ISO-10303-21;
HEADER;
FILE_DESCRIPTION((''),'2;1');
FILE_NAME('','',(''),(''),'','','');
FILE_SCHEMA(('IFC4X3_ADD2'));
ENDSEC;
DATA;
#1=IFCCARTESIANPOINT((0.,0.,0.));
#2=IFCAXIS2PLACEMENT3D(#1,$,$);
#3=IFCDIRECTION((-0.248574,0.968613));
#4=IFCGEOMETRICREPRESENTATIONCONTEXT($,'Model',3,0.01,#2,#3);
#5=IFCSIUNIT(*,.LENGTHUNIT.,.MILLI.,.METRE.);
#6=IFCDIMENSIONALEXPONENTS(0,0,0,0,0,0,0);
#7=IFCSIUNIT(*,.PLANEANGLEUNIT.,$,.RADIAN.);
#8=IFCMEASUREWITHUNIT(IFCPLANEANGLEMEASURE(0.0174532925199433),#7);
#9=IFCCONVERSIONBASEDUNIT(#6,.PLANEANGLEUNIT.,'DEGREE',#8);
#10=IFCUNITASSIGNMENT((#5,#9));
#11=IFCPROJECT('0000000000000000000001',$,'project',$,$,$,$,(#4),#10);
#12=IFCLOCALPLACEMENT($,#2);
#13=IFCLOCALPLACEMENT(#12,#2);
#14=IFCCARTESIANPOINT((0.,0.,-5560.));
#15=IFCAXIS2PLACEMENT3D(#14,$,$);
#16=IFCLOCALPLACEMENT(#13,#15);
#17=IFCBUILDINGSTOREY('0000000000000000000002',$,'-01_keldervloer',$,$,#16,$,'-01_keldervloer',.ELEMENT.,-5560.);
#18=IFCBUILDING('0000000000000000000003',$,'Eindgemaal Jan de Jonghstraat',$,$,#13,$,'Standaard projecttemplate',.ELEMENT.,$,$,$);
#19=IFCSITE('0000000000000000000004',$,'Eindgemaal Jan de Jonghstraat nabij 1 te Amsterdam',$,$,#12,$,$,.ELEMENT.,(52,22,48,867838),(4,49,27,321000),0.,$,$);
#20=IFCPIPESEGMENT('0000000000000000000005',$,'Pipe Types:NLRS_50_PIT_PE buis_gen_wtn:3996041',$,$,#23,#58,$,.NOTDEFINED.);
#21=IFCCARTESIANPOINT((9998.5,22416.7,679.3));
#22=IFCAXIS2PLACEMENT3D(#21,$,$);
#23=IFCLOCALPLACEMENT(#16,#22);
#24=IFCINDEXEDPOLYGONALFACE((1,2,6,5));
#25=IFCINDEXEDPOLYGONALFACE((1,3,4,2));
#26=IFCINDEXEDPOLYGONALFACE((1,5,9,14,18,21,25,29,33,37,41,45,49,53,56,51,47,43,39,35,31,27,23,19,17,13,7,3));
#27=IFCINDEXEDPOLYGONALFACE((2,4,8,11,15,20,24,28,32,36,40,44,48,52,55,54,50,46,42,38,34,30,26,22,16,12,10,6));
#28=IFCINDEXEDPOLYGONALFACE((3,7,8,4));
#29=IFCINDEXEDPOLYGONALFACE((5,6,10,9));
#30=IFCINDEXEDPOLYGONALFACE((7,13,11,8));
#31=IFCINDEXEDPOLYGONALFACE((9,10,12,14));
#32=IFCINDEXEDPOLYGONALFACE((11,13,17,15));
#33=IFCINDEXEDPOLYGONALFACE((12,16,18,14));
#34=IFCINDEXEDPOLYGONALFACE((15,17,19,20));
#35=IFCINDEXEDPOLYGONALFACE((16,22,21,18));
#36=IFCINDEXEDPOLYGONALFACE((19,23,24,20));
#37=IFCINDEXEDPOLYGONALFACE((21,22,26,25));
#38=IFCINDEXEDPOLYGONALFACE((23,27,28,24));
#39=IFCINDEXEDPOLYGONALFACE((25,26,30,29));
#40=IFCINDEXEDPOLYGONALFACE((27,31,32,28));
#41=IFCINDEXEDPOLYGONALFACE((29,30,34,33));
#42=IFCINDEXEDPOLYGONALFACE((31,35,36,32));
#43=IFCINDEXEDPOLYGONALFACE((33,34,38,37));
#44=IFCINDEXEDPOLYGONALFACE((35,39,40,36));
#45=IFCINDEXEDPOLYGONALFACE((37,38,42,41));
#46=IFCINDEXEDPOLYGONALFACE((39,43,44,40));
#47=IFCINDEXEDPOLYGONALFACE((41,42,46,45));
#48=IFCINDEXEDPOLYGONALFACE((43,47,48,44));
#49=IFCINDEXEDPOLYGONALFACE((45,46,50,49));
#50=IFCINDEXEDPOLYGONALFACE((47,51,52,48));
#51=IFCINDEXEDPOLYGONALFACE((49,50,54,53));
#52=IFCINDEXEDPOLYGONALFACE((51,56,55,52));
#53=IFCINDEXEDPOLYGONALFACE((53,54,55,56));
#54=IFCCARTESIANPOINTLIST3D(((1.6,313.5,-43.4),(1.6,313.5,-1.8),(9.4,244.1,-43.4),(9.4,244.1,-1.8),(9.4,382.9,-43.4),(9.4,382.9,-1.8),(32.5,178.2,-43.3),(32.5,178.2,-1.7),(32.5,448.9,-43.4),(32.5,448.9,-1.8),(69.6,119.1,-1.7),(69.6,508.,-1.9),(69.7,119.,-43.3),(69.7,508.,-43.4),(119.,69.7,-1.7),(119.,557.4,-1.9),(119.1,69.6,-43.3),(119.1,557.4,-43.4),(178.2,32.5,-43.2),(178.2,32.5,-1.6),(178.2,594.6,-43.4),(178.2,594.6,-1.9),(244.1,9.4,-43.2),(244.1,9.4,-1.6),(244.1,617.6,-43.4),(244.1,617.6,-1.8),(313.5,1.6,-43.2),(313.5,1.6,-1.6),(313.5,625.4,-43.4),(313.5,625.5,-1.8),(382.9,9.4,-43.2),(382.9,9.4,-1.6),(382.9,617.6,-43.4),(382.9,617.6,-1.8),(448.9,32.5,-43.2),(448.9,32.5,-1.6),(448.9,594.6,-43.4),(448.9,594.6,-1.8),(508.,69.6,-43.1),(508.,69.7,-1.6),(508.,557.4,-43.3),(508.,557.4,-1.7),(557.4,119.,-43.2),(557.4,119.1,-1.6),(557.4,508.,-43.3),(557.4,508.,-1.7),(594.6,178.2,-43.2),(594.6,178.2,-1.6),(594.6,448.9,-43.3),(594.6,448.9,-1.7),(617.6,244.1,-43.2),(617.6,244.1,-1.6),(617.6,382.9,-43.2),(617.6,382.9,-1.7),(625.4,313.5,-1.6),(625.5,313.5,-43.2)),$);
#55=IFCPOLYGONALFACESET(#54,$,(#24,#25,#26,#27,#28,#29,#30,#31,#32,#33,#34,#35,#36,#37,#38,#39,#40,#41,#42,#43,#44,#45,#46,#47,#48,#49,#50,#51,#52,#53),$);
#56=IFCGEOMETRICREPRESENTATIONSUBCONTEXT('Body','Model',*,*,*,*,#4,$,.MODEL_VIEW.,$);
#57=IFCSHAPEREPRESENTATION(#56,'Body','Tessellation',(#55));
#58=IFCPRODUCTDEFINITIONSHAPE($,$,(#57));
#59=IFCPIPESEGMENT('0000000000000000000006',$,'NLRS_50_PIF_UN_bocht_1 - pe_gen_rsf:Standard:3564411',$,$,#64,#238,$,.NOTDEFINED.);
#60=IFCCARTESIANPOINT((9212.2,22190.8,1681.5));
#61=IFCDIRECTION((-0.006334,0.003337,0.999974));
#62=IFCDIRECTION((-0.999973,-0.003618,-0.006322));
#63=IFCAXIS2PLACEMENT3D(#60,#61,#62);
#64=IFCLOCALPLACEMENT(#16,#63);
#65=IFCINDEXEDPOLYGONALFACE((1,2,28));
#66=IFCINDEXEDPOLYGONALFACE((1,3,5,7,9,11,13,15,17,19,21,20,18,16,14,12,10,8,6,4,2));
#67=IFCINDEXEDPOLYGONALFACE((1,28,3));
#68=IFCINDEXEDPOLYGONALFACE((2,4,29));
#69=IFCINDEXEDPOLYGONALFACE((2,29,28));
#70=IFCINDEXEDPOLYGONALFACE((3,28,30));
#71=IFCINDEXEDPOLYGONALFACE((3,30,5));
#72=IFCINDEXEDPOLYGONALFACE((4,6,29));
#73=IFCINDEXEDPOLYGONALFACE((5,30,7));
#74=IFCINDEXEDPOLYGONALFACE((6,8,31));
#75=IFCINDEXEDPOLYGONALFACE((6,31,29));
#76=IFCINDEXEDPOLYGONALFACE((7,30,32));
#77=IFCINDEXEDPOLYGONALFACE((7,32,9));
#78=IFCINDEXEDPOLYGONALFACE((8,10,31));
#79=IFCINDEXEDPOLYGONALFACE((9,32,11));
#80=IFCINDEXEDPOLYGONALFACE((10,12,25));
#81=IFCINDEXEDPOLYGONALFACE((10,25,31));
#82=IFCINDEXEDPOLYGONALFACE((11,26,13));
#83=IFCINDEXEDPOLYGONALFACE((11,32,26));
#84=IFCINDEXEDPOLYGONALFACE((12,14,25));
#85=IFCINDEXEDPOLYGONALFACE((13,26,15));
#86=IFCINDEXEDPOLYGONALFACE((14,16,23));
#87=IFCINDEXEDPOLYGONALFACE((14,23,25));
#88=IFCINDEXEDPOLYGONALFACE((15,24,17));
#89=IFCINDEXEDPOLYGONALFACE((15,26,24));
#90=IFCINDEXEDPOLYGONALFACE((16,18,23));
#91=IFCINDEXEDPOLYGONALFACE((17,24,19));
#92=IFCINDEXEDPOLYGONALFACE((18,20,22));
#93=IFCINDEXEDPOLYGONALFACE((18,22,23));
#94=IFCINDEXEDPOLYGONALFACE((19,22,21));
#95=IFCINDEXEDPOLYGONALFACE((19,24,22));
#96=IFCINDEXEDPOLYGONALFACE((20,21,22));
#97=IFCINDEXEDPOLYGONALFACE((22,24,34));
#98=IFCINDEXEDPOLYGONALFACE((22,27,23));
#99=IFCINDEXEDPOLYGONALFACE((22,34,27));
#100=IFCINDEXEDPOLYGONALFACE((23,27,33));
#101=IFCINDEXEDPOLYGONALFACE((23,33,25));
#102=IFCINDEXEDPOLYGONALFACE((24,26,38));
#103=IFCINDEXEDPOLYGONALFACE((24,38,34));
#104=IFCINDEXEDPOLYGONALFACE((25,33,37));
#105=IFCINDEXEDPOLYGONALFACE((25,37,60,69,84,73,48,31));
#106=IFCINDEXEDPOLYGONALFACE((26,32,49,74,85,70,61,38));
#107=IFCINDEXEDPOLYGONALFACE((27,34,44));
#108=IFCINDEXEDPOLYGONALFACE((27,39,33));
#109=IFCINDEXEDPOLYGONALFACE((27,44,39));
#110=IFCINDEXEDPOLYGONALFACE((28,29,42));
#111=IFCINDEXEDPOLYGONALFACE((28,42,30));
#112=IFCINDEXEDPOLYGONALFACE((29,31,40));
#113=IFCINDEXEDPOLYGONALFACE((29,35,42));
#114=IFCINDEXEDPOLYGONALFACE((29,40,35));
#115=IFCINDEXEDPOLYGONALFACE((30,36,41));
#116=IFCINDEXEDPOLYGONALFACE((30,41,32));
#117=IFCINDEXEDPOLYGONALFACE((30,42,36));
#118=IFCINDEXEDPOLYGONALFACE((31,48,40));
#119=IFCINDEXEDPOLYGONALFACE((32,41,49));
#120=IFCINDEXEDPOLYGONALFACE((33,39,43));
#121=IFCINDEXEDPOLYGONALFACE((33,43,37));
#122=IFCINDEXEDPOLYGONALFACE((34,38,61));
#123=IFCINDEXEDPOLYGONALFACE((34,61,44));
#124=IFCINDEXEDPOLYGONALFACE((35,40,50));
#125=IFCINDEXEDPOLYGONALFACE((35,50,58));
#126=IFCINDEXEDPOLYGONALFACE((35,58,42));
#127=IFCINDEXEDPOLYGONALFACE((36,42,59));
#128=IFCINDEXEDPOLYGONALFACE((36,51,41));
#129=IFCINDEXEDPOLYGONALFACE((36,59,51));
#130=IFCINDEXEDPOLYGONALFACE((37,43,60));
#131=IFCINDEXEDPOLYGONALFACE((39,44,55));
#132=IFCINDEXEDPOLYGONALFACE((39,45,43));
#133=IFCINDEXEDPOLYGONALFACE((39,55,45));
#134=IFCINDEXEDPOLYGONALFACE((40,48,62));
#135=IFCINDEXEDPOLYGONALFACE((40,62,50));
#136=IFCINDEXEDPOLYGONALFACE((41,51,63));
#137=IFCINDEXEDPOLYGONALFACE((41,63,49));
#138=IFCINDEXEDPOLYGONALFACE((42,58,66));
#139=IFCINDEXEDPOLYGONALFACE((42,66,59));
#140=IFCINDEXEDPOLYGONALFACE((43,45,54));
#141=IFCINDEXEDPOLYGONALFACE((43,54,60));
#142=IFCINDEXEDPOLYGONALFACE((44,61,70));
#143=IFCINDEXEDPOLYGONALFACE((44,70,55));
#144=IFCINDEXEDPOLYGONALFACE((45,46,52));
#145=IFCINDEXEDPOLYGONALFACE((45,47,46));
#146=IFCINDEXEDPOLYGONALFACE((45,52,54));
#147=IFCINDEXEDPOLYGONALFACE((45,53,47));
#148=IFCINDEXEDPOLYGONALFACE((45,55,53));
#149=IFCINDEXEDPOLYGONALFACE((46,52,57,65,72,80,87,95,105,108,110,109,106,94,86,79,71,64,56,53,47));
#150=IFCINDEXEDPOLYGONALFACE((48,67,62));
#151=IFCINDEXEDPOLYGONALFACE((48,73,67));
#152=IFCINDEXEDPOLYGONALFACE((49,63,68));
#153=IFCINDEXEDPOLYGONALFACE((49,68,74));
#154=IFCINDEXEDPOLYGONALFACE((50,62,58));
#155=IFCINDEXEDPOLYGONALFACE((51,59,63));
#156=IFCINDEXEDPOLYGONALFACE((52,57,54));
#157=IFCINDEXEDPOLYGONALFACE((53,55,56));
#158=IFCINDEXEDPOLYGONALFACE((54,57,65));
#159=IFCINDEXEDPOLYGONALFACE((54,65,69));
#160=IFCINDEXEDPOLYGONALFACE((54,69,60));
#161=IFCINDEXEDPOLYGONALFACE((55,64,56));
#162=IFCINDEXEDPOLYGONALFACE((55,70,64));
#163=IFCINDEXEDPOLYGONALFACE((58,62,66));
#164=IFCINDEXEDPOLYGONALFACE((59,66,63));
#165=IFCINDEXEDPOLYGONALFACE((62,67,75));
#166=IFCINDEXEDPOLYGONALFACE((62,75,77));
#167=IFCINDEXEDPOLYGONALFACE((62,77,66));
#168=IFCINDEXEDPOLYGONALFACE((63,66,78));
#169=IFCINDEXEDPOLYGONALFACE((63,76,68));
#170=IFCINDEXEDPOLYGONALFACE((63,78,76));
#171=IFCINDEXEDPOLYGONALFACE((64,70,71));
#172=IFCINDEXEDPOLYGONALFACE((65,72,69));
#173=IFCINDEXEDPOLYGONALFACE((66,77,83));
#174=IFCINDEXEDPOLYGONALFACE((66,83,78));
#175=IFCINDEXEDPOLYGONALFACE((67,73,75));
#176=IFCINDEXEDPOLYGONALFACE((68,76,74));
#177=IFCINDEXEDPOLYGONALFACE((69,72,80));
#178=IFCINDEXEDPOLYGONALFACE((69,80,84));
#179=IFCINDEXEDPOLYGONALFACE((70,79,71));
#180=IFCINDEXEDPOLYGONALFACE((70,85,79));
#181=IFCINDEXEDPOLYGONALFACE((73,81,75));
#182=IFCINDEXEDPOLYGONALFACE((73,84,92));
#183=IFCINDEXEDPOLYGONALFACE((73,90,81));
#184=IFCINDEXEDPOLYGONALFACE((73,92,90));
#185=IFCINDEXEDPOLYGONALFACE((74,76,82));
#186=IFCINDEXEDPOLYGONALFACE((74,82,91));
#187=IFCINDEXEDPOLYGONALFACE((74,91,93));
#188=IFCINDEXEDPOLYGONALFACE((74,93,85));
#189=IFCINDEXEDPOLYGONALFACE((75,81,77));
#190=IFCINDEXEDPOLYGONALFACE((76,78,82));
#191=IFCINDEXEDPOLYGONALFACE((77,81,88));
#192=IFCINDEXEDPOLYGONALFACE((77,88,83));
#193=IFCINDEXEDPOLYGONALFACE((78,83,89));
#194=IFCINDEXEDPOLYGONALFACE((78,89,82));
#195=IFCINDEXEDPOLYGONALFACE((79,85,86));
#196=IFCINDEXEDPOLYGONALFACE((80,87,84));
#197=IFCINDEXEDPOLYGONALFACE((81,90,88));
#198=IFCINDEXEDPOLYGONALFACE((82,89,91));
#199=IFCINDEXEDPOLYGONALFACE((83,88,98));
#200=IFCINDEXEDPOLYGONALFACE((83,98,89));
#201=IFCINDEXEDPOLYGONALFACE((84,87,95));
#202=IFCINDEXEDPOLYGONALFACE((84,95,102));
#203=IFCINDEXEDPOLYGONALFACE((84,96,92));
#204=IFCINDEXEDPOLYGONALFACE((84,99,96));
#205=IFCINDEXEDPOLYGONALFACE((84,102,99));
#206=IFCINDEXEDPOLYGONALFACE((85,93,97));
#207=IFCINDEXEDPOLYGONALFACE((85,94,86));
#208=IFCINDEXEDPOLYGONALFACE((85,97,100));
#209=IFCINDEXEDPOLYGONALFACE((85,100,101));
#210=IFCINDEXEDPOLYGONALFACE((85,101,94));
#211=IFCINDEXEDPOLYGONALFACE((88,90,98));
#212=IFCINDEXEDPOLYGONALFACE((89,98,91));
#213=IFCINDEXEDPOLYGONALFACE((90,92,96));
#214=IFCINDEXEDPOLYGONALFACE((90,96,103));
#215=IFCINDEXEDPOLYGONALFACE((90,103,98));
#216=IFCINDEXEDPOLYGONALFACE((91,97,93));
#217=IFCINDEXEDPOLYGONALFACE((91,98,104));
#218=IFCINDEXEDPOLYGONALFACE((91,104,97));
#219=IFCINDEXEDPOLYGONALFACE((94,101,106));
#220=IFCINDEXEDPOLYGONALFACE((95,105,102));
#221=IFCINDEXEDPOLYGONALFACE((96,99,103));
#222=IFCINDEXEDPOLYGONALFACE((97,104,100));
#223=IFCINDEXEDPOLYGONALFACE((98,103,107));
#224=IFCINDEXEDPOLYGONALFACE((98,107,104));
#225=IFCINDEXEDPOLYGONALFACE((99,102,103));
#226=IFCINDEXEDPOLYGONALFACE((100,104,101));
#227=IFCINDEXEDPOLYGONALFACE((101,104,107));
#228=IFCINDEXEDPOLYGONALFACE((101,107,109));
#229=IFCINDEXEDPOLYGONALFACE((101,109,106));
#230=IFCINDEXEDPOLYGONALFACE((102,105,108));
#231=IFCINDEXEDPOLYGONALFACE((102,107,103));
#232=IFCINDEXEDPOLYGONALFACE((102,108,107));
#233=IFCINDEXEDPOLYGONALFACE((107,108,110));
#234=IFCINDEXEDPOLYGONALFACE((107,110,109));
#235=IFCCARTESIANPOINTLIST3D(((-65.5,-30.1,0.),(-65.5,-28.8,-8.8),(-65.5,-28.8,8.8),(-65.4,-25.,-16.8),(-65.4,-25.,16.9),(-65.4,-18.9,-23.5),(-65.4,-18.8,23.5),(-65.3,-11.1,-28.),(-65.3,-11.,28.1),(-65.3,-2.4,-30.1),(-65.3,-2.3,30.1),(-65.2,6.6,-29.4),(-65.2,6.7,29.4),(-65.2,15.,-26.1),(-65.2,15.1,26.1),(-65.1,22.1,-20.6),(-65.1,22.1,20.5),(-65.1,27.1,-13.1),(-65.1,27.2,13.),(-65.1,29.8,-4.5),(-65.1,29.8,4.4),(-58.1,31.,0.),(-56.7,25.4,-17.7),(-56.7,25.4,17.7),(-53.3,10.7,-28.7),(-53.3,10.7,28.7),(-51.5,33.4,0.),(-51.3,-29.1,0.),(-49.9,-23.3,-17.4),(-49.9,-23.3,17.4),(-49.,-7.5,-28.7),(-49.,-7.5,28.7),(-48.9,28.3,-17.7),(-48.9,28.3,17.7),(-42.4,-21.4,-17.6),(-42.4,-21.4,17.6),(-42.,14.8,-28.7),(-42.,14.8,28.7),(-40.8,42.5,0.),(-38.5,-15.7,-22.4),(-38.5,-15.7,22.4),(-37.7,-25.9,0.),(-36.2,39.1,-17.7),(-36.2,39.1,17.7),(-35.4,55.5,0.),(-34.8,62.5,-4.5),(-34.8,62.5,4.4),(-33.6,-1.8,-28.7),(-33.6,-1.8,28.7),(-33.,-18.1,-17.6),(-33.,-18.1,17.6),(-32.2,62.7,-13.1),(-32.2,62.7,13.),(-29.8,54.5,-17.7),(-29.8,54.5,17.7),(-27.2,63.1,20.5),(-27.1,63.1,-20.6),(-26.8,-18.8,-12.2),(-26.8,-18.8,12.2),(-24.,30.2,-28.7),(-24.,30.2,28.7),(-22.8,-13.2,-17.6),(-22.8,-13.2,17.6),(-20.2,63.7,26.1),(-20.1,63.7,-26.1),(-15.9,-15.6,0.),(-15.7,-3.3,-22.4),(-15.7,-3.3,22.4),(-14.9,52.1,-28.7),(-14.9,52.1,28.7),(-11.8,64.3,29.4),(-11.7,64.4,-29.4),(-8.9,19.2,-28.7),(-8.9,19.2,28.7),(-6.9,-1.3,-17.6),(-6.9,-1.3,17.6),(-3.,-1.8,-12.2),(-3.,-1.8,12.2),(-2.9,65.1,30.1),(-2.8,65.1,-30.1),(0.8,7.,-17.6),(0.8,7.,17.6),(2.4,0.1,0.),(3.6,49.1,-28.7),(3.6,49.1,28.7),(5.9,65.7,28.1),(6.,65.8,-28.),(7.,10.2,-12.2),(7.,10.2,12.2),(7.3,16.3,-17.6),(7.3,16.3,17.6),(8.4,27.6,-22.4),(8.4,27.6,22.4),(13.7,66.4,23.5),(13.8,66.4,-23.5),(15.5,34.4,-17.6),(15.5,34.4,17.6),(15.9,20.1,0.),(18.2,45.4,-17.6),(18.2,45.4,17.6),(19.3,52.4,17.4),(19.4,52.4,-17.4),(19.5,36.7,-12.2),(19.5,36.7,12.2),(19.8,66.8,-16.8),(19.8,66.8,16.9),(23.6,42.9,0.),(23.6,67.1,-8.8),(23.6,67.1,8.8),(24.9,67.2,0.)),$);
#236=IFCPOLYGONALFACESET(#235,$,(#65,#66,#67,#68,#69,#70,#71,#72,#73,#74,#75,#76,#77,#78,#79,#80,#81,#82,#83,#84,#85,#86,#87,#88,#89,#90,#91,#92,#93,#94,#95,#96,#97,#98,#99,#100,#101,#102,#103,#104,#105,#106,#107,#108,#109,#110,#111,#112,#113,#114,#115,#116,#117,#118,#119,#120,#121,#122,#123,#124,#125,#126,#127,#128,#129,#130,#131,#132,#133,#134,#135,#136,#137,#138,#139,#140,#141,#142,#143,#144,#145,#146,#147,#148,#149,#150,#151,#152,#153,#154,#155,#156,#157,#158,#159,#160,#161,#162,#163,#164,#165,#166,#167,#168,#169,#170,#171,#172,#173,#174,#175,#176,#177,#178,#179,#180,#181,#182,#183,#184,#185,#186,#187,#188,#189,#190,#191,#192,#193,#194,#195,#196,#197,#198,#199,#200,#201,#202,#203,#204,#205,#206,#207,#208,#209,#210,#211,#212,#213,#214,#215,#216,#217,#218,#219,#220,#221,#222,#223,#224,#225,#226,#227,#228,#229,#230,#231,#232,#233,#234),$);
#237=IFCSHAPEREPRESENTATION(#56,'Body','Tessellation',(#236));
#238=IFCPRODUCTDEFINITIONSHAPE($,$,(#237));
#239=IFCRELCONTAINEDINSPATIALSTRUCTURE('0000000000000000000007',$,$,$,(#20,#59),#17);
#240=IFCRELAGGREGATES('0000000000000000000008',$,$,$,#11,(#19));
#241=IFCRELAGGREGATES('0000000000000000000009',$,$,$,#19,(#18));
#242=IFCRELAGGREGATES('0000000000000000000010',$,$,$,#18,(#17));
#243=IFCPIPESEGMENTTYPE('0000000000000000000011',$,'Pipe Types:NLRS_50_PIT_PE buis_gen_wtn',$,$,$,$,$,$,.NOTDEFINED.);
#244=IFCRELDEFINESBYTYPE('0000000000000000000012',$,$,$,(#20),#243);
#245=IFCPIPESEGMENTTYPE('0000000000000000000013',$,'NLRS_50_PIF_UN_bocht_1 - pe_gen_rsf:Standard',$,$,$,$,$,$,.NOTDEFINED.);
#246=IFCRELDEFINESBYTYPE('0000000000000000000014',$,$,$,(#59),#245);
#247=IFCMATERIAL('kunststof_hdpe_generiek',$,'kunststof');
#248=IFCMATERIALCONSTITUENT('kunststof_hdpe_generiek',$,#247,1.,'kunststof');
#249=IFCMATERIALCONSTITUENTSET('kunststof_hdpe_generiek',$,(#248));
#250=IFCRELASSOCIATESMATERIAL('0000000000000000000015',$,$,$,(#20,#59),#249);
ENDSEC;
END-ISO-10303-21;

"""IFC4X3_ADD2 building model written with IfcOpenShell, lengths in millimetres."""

from ifc_helpers import new_model, entity, si_unit, converted_unit, direction, frame, origin, origin_2d_with_axis, place, context, subcontext, project, spatial, circle, extrude, source, transform, mapped, material, constituent, constituent_set, type_object, type_shapes, element, save


model = new_model("IFC4X3_ADD2")

# Units and contexts
model_context = context("Model", 3, precision=0.01, world=origin(), true_north=direction((-0.248574, 0.968613)))
body_context = subcontext(model_context, "Body", "Model", "MODEL_VIEW")
ifc_project = project(units=[si_unit("LENGTHUNIT", "METRE", prefix="MILLI"), converted_unit("PLANEANGLEUNIT", "DEGREE", entity("IfcPlaneAngleMeasure", 0.0174532925199433), si_unit("PLANEANGLEUNIT", "RADIAN"), dimensions=[0, 0, 0, 0, 0, 0, 0])], contexts=[model_context])

# Site, building, storey
site_placement = place(None, origin())
site = spatial("IfcSite", under=ifc_project, at=site_placement, Name="Eindgemaal Jan de Jonghstraat nabij 1 te Amsterdam", CompositionType="ELEMENT", RefLatitude=(52, 22, 48, 867838), RefLongitude=(4, 49, 27, 321000), RefElevation=0.0)
building_placement = place(site_placement, origin())
building = spatial("IfcBuilding", under=site, at=building_placement, Name="Eindgemaal Jan de Jonghstraat", LongName="Standaard projecttemplate", CompositionType="ELEMENT")
storey_placement = place(building_placement, frame((0.0, 0.0, -5560.0)))
storey = spatial("IfcBuildingStorey", under=building, at=storey_placement, Name="-01_keldervloer", LongName="-01_keldervloer", CompositionType="ELEMENT", Elevation=-5560.0)

# Pipe segments
ifc_material_1 = material(Name="kunststof_hdpe_generiek", Category="kunststof")
ifc_constituent_1 = constituent(ifc_material_1, Name="kunststof_hdpe_generiek", Category="kunststof", fraction=1.0)
ifc_constituent_set_1 = constituent_set(constituents=[ifc_constituent_1], Name="kunststof_hdpe_generiek")
pipe_segment_type_1 = type_object("IfcPipeSegmentType", Name="Pipe Types:NLRS_50_PIT_PE buis_gen_wtn", PredefinedType="NOTDEFINED")
pipe_segment_1_placement = place(storey_placement, frame((9998.5, 22416.7, 679.3)))
element("IfcPipeSegment", 1, at=pipe_segment_1_placement, inside=storey, type_object=pipe_segment_type_1, material=ifc_constituent_set_1, Name="Pipe Types:NLRS_50_PIT_PE buis_gen_wtn:3996041", PredefinedType="NOTDEFINED", context=body_context, shape_type="SweptSolid", body=[
    extrude(circle(Radius=311.9, at=origin_2d_with_axis()), frame((313.5, 313.5, -43.3), z_axis=(-0.000291, 0.000376, 1.0), x_axis=(1.0, 0.0, 0.000291)), (0.0, 0.0, 1.0), 41.6),
])
pipe_segment_type_2 = type_object("IfcPipeSegmentType", Name="NLRS_50_PIF_UN_bocht_1 - pe_gen_rsf:Standard", PredefinedType="NOTDEFINED")
trimmed_curve_1 = entity("IfcTrimmedCurve", entity("IfcCircle", entity("IfcAxis2Placement2D", entity("IfcCartesianPoint", [-30.0, 0.0]), entity("IfcDirection", [-0.078558, 0.99691])), 30.0), [entity("IfcParameterValue", 265.494318)], [entity("IfcParameterValue", 0.0)], True, "PARAMETER")
shared_shape_1 = source(origin(), body_context, "Body", "AdvancedSweptSolid", [
    entity("IfcSurfaceCurveSweptAreaSolid", entity("IfcCircleProfileDef", "AREA", None, entity("IfcAxis2Placement2D", entity("IfcCartesianPoint", [30.1, 0.0]), entity("IfcDirection", [1.0, 0.0])), 30.1), entity("IfcAxis2Placement3D", entity("IfcCartesianPoint", [-35.2, 62.5, 0.0]), entity("IfcDirection", [0.0, 0.0, -1.0]), entity("IfcDirection", [0.99691, 0.078558, 0.0])), trimmed_curve_1, entity("IfcParameterValue", 0.0), entity("IfcParameterValue", 94.505682), entity("IfcSurfaceOfLinearExtrusion", entity("IfcArbitraryOpenProfileDef", "CURVE", None, trimmed_curve_1), entity("IfcAxis2Placement3D", entity("IfcCartesianPoint", [0.0, 0.0, -304.8])), entity("IfcDirection", [0.0, 0.0, 1.0]), 1.0)),
])
type_shapes(pipe_segment_type_2, [shared_shape_1])
pipe_segment_2_placement = place(storey_placement, frame((9212.2, 22190.8, 1681.5), z_axis=(-0.006334, 0.003337, 0.999974), x_axis=(-0.999973, -0.003618, -0.006322)))
element("IfcPipeSegment", 2, at=pipe_segment_2_placement, inside=storey, type_object=pipe_segment_type_2, material=ifc_constituent_set_1, Name="NLRS_50_PIF_UN_bocht_1 - pe_gen_rsf:Standard:3564411", PredefinedType="NOTDEFINED", context=body_context, shape_type="MappedRepresentation", body=[
    mapped(shared_shape_1, transform((0.0, 0.0, 0.0), scale=1.0)),
])

save(model, "model.ifc")
